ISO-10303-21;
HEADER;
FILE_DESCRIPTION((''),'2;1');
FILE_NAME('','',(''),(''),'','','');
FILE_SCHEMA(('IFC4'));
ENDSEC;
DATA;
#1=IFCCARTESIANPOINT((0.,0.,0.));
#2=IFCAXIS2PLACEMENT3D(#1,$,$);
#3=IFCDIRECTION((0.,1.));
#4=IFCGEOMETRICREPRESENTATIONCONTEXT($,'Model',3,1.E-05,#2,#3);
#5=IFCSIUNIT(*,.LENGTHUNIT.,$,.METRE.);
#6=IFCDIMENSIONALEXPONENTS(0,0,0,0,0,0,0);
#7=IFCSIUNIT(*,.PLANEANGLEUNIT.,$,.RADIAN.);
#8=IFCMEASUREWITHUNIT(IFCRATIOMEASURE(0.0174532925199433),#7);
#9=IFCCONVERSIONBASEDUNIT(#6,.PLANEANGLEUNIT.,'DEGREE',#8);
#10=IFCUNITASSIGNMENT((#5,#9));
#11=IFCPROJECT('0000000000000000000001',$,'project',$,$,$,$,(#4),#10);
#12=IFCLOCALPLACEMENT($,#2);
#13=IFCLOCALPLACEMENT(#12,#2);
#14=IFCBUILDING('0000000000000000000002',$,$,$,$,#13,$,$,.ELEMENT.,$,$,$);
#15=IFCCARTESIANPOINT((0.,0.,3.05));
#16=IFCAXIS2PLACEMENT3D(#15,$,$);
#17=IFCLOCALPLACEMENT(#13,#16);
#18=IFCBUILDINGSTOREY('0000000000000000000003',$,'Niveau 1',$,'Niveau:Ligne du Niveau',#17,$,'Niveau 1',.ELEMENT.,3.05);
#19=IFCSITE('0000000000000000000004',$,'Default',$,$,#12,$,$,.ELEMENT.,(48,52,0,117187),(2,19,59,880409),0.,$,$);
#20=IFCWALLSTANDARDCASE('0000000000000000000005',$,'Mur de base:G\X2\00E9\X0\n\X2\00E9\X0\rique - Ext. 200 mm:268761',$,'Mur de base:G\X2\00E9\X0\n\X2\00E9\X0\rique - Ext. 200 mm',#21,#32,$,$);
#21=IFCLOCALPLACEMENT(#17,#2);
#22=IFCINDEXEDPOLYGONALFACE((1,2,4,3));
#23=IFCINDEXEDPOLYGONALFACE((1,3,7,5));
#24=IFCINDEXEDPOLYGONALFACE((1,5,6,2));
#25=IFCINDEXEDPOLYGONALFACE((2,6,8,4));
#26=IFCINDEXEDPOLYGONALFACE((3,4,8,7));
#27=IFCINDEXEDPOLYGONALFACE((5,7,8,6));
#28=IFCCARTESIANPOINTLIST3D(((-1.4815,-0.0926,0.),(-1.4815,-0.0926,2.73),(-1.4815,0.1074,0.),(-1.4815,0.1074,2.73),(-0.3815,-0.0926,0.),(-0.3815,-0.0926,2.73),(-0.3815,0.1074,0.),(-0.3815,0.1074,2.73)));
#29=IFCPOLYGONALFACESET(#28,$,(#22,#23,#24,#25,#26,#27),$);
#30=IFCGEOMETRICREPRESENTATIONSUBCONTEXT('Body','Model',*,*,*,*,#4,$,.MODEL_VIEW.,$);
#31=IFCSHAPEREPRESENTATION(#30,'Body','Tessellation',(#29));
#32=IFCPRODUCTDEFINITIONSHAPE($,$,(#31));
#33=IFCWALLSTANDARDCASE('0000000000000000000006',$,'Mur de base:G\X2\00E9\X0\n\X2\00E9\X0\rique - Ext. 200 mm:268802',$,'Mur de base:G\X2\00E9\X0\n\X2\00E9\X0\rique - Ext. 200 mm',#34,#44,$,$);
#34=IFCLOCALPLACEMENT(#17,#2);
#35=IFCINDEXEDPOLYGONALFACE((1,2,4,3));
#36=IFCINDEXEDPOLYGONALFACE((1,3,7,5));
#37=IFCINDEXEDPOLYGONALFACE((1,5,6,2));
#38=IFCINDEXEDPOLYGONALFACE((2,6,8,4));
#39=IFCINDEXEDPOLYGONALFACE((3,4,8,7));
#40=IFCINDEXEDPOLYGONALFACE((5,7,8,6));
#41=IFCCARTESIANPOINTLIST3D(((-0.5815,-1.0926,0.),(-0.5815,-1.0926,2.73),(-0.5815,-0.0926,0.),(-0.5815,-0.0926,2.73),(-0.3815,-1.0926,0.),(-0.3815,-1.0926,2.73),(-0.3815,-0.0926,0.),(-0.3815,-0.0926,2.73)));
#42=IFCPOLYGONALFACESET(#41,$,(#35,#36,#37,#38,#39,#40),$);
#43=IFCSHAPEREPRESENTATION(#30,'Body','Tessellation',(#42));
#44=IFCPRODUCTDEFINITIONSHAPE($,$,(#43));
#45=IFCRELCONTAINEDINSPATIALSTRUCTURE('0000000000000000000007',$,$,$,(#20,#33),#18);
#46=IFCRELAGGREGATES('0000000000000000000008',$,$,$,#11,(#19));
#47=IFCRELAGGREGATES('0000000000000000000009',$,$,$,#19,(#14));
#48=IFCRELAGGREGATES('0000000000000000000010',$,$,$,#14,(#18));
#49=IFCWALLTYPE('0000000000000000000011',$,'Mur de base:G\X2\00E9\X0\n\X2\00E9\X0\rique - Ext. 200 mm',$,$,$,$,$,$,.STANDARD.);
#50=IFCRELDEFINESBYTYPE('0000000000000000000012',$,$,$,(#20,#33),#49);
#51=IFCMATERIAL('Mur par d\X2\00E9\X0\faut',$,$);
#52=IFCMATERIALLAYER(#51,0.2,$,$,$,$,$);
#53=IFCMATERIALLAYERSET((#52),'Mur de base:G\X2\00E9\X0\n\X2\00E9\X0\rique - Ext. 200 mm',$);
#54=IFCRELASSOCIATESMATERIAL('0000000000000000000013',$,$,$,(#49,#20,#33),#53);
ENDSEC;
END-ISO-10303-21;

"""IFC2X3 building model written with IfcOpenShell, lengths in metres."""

from ifc_helpers import new_model, entity, si_unit, converted_unit, direction, frame, frame_2d, origin, place, context, subcontext, project, spatial, polyline, rectangle, extrude, clip, bounded_halfspace, material, layer, layer_set, layer_usage, type_object, element, save


model = new_model("IFC2X3")

# Units and contexts
model_context = context("Model", 3, precision=1e-05, world=origin(), true_north=direction((0.0, 1.0)))
body_context = subcontext(model_context, "Body", "Model", "MODEL_VIEW")
ifc_project = project(units=[si_unit("LENGTHUNIT", "METRE"), converted_unit("PLANEANGLEUNIT", "DEGREE", entity("IfcRatioMeasure", 0.0174532925199433), si_unit("PLANEANGLEUNIT", "RADIAN"), dimensions=[0, 0, 0, 0, 0, 0, 0])], contexts=[model_context])

# Site, building, storey
site_placement = place(None, origin())
site = spatial("IfcSite", under=ifc_project, at=site_placement, Name="Default", CompositionType="ELEMENT", RefLatitude=(48, 52, 0, 117187), RefLongitude=(2, 19, 59, 880409), RefElevation=0.0)
building_placement = place(site_placement, origin())
building = spatial("IfcBuilding", under=site, at=building_placement, CompositionType="ELEMENT")
storey_placement = place(building_placement, frame((0.0, 0.0, 3.05)))
storey = spatial("IfcBuildingStorey", under=building, at=storey_placement, Name="Niveau 1", ObjectType="Niveau:Ligne du Niveau", LongName="Niveau 1", CompositionType="ELEMENT", Elevation=3.05)

# Shared definitions
ifc_material_1 = material(Name="Mur par défaut")
ifc_layer_1 = layer(ifc_material_1, 0.2)
ifc_layer_set_1 = layer_set([ifc_layer_1], Name="Mur de base:Générique - Ext. 200 mm")
wall_type = type_object("IfcWallType", Name="Mur de base:Générique - Ext. 200 mm", PredefinedType="STANDARD", material=ifc_layer_set_1)

# Walls
ifc_layer_usage_1 = layer_usage(ifc_layer_set_1, "AXIS2", "NEGATIVE", 0.1)
wall_1_placement = place(storey_placement, frame((-1.4815, 0.0074, 0.0)))
element("IfcWallStandardCase", 1, at=wall_1_placement, inside=storey, type_object=wall_type, material=ifc_layer_usage_1, Name="Mur de base:Générique - Ext. 200 mm:268761", ObjectType="Mur de base:Générique - Ext. 200 mm", context=body_context, shape_type="Clipping", body=[
    clip(extrude(rectangle(XDim=1.1, YDim=0.2, at=frame_2d((0.55, 0.0), x_axis=(-1.0, 0.0))), origin(), (0.0, 0.0, 1.0), 2.73), bounded_halfspace(frame((0.0, -0.1, 2.73), z_axis=(0.0, 0.0, -1.0), x_axis=(1.0, 0.0, 0.0)), True, frame((0.0, -0.1, 2.73)), polyline([(0.0, 0.0), (0.9, 0.0), (1.1, 0.0), (1.1, 0.2), (0.0, 0.2), (0.0, 0.0)]))),
])
ifc_layer_usage_2 = layer_usage(ifc_layer_set_1, "AXIS2", "NEGATIVE", 0.1)
wall_2_placement = place(storey_placement, frame((-0.4815, -0.0926, 0.0), z_axis=(0.0, 0.0, 1.0), x_axis=(0.0, -1.0, 0.0)))
element("IfcWallStandardCase", 2, at=wall_2_placement, inside=storey, type_object=wall_type, material=ifc_layer_usage_2, Name="Mur de base:Générique - Ext. 200 mm:268802", ObjectType="Mur de base:Générique - Ext. 200 mm", context=body_context, shape_type="Clipping", body=[
    clip(extrude(rectangle(XDim=1.0, YDim=0.2, at=frame_2d((0.5, 0.0), x_axis=(-1.0, 0.0))), origin(), (0.0, 0.0, 1.0), 2.73), bounded_halfspace(frame((0.0, -0.1, 2.73), z_axis=(0.0, 0.0, -1.0), x_axis=(0.0, 1.0, 0.0)), True, frame((0.0, -0.1, 2.73)), polyline([(0.0, 0.0), (1.0, 0.0), (1.0, 0.2), (0.0, 0.2), (0.0, 0.0)]))),
])

save(model, "model.ifc")
